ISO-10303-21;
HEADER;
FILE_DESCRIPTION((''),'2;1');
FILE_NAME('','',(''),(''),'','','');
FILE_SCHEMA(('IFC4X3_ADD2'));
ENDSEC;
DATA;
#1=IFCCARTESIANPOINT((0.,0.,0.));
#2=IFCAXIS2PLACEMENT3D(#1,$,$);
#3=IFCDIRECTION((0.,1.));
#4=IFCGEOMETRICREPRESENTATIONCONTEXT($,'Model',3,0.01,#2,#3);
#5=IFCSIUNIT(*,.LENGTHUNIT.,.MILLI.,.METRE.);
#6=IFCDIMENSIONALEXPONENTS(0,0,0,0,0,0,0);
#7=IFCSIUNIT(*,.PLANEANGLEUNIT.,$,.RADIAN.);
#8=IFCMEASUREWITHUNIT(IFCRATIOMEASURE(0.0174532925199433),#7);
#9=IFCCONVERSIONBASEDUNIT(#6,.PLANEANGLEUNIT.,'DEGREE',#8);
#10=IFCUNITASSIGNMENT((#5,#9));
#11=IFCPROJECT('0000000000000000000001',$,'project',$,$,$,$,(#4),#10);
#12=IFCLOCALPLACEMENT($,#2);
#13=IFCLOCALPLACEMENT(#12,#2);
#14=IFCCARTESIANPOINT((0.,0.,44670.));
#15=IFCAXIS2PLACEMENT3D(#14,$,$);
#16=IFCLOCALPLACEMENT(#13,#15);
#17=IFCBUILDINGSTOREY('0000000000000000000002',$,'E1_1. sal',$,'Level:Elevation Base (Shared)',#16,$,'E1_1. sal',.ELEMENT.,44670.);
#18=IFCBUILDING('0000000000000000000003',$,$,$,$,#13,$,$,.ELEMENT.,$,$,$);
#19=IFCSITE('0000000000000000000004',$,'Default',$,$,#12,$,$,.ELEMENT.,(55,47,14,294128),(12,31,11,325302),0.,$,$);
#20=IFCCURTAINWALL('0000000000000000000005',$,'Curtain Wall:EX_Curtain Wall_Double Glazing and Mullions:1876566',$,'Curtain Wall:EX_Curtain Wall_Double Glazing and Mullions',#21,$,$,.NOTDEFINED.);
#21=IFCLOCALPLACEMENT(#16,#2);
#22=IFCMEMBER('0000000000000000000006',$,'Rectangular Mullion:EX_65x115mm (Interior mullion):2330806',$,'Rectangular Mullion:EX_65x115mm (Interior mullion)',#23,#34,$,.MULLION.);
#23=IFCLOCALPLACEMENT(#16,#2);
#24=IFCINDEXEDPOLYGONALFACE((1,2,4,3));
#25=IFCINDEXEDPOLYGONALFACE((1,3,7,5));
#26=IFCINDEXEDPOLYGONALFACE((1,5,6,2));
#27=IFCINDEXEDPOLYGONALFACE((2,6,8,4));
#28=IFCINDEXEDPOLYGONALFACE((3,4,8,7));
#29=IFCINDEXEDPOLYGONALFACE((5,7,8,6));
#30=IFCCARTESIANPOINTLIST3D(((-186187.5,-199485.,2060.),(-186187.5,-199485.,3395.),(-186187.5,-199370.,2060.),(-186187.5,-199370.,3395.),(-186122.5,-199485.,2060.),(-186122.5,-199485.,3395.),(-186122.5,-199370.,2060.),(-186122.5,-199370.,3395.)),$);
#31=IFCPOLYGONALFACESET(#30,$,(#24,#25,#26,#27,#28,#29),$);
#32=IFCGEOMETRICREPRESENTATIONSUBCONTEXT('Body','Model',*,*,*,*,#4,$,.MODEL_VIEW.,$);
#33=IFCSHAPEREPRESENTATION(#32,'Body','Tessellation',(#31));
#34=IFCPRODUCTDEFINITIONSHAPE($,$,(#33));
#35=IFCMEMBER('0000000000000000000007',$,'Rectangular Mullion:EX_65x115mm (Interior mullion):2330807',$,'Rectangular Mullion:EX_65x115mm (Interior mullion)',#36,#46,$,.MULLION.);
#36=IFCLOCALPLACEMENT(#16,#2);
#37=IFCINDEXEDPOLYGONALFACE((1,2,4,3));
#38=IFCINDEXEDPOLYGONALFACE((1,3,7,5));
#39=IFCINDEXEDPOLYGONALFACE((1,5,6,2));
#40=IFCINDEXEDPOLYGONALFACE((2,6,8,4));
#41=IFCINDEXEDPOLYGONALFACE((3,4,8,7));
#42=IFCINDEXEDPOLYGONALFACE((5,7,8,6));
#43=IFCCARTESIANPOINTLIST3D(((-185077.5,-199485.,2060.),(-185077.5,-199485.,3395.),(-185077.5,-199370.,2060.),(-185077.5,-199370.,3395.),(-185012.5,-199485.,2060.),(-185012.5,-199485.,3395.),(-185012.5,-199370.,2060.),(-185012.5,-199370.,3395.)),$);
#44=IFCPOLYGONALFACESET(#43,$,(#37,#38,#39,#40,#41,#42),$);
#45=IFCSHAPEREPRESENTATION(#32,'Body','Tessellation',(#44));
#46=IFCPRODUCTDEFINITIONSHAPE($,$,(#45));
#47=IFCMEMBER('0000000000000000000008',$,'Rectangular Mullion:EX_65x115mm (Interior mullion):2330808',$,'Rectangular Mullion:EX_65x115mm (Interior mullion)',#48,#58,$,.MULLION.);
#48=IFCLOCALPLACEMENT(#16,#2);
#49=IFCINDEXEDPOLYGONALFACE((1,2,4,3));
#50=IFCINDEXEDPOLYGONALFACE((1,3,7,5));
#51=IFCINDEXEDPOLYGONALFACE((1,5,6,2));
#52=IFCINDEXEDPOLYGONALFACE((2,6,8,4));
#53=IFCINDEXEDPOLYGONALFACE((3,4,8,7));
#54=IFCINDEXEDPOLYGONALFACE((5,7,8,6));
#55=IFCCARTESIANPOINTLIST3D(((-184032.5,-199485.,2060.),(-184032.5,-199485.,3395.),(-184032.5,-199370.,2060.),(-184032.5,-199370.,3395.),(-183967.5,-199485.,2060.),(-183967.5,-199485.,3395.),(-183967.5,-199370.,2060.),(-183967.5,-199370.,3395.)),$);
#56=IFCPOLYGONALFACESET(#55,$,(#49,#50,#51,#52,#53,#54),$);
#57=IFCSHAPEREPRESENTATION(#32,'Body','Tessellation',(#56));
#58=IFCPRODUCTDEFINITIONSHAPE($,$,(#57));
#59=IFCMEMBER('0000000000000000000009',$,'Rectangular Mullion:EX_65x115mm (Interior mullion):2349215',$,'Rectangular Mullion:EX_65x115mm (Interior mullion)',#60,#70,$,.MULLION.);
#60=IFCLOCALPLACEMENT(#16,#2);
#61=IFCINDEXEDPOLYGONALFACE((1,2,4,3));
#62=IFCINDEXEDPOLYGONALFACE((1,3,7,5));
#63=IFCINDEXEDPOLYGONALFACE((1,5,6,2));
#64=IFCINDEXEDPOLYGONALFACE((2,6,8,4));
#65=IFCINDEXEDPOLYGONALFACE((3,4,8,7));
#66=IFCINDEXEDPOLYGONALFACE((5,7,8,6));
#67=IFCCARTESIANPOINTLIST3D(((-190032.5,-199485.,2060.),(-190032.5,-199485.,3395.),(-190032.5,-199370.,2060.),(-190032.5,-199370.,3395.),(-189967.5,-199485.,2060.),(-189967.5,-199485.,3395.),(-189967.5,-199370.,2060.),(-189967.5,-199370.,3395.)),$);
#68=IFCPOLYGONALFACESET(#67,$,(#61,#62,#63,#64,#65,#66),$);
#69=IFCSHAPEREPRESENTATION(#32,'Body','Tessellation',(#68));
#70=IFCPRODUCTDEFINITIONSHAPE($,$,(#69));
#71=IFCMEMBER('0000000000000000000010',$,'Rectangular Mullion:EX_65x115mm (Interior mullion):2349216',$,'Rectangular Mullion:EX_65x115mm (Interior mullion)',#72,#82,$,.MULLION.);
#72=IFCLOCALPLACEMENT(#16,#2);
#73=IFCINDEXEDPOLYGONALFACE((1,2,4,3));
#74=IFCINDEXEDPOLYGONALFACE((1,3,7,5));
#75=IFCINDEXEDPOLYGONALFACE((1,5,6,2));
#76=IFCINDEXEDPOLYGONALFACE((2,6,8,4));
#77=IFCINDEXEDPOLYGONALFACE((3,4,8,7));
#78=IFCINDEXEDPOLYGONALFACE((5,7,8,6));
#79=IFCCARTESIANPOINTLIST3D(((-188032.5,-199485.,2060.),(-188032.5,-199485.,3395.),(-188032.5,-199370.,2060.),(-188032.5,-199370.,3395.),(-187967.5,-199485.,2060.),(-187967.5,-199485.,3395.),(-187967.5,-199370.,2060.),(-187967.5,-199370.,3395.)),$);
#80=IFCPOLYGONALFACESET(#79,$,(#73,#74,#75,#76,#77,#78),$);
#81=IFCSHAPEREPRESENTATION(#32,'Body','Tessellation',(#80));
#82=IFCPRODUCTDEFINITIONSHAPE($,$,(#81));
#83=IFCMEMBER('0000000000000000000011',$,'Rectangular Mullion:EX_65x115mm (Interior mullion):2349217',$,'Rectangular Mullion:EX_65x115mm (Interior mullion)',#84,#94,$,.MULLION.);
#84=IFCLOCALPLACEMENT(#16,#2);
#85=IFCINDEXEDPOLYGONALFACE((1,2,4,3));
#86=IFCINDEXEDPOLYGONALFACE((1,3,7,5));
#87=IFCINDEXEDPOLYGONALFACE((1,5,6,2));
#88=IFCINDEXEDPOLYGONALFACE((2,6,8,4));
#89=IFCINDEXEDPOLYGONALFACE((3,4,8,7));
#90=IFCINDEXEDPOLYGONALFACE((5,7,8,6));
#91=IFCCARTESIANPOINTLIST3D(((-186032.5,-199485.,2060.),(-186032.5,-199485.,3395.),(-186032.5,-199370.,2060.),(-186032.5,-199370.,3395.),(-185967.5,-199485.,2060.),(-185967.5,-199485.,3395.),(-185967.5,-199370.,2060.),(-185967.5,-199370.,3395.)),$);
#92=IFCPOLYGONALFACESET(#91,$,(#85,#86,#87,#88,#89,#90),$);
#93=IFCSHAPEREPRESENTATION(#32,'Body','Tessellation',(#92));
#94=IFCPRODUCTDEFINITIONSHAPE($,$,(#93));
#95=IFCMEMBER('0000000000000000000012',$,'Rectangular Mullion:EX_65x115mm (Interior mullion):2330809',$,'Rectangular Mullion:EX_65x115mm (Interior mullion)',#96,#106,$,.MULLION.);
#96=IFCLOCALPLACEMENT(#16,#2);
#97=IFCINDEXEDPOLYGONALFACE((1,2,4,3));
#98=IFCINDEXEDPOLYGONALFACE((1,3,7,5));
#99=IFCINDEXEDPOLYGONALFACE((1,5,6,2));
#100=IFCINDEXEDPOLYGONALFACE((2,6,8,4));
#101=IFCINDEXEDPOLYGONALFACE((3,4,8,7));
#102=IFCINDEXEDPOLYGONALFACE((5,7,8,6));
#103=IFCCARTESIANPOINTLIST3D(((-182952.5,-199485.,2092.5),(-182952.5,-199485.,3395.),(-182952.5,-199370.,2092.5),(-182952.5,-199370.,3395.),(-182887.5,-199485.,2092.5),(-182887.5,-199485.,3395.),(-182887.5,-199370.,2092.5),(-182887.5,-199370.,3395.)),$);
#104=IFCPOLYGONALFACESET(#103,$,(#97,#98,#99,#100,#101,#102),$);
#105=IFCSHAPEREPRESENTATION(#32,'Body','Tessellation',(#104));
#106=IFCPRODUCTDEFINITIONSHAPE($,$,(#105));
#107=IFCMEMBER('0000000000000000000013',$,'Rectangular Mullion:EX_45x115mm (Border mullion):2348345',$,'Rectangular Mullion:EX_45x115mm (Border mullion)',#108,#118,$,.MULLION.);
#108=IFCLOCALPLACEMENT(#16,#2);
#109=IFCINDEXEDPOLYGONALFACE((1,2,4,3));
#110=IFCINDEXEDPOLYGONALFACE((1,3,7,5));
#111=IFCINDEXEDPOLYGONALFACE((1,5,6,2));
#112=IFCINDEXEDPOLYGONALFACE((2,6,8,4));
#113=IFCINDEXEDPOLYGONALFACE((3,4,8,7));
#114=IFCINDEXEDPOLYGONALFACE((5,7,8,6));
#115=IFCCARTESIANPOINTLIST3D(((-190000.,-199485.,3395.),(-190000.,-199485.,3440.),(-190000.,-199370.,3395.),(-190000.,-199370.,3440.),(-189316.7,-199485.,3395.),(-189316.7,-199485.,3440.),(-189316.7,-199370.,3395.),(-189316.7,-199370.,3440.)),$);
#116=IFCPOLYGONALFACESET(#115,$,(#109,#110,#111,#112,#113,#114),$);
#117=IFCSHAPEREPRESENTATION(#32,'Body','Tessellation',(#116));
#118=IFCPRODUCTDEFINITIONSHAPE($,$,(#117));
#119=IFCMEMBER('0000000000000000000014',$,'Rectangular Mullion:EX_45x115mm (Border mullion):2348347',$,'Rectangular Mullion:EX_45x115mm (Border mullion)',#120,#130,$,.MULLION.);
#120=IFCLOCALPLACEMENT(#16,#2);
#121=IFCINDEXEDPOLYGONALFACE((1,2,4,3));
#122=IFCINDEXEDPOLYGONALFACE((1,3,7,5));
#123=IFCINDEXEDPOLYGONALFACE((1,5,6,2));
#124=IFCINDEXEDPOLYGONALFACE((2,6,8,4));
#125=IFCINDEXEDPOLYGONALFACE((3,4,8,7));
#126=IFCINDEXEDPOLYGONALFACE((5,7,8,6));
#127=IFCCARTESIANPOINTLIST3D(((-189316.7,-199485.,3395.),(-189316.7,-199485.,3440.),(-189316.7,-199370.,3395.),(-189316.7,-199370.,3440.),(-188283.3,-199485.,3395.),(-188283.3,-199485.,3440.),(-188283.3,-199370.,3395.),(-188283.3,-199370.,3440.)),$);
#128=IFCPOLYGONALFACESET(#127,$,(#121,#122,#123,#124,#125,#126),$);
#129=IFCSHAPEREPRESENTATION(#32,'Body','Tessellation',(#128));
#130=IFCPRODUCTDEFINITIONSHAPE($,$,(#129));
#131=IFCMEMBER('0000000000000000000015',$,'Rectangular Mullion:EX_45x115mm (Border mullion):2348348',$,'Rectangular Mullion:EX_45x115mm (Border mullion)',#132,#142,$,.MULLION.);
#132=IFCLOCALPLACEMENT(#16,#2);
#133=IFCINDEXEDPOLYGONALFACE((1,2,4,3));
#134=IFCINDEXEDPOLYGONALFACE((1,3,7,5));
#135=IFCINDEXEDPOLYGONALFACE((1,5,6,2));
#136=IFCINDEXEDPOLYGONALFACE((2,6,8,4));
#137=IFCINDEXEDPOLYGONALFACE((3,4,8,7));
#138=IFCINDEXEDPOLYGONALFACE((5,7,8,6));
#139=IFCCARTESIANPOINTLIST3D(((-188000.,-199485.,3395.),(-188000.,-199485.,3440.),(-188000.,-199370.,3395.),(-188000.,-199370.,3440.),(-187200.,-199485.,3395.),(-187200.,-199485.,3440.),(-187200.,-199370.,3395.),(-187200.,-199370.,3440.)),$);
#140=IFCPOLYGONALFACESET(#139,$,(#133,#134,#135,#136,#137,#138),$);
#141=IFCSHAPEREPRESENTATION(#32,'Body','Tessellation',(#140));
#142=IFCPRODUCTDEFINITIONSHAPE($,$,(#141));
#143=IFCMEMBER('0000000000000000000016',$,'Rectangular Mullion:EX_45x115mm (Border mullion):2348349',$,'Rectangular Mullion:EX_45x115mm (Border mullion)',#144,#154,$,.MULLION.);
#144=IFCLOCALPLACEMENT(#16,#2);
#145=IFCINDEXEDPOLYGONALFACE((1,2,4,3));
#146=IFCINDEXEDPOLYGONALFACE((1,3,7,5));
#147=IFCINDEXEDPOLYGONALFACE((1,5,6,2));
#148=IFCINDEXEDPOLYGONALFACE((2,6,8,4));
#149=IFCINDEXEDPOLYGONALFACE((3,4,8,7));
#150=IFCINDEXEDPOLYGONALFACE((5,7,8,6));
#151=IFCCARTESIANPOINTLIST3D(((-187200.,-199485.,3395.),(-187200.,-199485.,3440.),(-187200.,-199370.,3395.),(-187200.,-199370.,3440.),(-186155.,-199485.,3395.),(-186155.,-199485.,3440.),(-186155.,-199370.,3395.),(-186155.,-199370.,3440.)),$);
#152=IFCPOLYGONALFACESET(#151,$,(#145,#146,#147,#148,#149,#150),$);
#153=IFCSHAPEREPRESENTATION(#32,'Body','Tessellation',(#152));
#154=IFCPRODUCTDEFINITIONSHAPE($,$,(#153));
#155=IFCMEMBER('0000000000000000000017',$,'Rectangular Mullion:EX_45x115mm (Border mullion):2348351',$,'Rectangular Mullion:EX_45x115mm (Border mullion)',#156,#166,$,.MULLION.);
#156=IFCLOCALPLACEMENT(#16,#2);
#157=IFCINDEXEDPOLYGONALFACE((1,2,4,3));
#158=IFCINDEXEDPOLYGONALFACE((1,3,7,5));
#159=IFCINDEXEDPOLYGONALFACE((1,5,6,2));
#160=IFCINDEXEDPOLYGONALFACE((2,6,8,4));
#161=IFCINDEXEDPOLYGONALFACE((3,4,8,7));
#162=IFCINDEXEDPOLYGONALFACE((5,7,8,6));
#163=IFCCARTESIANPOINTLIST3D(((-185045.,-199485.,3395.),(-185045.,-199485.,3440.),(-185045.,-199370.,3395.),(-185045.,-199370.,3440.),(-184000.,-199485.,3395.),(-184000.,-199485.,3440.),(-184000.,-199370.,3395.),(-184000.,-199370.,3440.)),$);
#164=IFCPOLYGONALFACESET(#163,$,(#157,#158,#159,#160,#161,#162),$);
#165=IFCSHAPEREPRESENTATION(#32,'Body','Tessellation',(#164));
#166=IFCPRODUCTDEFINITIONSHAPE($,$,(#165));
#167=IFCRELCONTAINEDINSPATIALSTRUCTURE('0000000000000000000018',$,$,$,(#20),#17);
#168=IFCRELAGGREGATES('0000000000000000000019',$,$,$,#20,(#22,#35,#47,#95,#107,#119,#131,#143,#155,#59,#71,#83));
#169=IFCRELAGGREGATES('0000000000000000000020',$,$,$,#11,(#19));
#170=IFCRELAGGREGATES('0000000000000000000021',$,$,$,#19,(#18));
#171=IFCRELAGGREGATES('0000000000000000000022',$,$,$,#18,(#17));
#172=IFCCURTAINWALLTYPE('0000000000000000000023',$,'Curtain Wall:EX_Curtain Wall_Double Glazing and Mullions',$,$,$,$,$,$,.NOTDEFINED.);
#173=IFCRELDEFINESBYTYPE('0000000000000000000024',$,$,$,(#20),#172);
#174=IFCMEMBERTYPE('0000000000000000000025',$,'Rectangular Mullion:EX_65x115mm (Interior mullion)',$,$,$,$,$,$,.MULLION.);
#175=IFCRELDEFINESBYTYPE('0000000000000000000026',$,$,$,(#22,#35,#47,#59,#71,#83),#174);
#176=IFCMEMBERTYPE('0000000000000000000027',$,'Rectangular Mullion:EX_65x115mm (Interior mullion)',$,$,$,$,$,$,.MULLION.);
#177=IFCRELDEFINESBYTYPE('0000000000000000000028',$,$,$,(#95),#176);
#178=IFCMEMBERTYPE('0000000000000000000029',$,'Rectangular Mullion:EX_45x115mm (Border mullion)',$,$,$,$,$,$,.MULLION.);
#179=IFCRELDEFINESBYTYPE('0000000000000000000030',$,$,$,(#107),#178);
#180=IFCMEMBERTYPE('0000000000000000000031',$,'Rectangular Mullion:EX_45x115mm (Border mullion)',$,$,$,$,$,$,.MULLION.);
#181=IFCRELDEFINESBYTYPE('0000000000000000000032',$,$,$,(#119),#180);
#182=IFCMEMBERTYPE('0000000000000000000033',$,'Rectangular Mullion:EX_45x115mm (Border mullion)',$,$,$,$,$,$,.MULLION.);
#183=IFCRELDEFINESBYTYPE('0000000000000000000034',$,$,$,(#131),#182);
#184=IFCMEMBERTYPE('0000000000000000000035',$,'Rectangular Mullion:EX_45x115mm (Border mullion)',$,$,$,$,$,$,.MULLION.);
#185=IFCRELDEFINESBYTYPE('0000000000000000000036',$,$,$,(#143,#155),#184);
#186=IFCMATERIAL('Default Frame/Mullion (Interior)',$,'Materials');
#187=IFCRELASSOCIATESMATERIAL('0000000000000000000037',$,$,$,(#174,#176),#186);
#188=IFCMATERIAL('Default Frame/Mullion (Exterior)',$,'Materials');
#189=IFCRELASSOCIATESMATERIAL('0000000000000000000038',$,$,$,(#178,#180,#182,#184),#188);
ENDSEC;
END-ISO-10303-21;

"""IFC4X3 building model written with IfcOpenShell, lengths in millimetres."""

from ifc_helpers import new_model, entity, si_unit, converted_unit, direction, frame, origin, origin_2d_with_axis, place, context, subcontext, project, spatial, rectangle, extrude, source, transform, mapped, material, material_profile, profile_set, type_object, type_shapes, element, aggregate, save


model = new_model("IFC4X3")

# Units and contexts
model_context = context("Model", 3, precision=0.01, world=origin(), true_north=direction((0.0, 1.0)))
body_context = subcontext(model_context, "Body", "Model", "MODEL_VIEW")
ifc_project = project(units=[si_unit("LENGTHUNIT", "METRE", prefix="MILLI"), converted_unit("PLANEANGLEUNIT", "DEGREE", entity("IfcRatioMeasure", 0.0174532925199433), si_unit("PLANEANGLEUNIT", "RADIAN"), dimensions=[0, 0, 0, 0, 0, 0, 0])], contexts=[model_context])

# Site, building, storey
site_placement = place(None, origin())
site = spatial("IfcSite", under=ifc_project, at=site_placement, Name="Default", CompositionType="ELEMENT", RefLatitude=(55, 47, 14, 294128), RefLongitude=(12, 31, 11, 325302), RefElevation=0.0)
building_placement = place(site_placement, origin())
building = spatial("IfcBuilding", under=site, at=building_placement, CompositionType="ELEMENT")
storey_placement = place(building_placement, frame((0.0, 0.0, 44670.0)))
storey = spatial("IfcBuildingStorey", under=building, at=storey_placement, Name="E1_1. sal", ObjectType="Level:Elevation Base (Shared)", LongName="E1_1. sal", CompositionType="ELEMENT", Elevation=44670.0)

# Curtain wall, members
curtain_wall_type = type_object("IfcCurtainWallType", Name="Curtain Wall:EX_Curtain Wall_Double Glazing and Mullions", PredefinedType="NOTDEFINED")
curtain_wall_placement = place(storey_placement, frame((0.0, 0.0, -44670.0)))
curtain_wall = element("IfcCurtainWall", 1, at=curtain_wall_placement, inside=storey, type_object=curtain_wall_type, Name="Curtain Wall:EX_Curtain Wall_Double Glazing and Mullions:1876566", ObjectType="Curtain Wall:EX_Curtain Wall_Double Glazing and Mullions", PredefinedType="NOTDEFINED")
ifc_material_1 = material(Name="Default Frame/Mullion (Interior)", Category="Materials")
ifc_material_profile_1 = material_profile(ifc_material_1, rectangle(XDim=115.0, YDim=65.0, at=origin_2d_with_axis()), Name="EX_65x115mm (Interior mullion)")
ifc_profile_set_1 = profile_set([ifc_material_profile_1], Name="EX_65x115mm (Interior mullion)")
member_type_1 = type_object("IfcMemberType", Name="Rectangular Mullion:EX_65x115mm (Interior mullion)", PredefinedType="MULLION", material=ifc_profile_set_1)
shared_shape_1 = source(origin(), body_context, "Body", "SweptSolid", [
    extrude(rectangle(XDim=115.0, YDim=65.0, at=origin_2d_with_axis()), frame((0.0, -57.5, -1335.0), z_axis=(0.0, 0.0, 1.0), x_axis=(0.0, -1.0, 0.0)), (0.0, 0.0, 1.0), 1335.0),
])
type_shapes(member_type_1, [shared_shape_1])
member_1_placement = place(curtain_wall_placement, frame((-186155.0, -199485.0, 46730.0), z_axis=(0.0, 0.0, -1.0), x_axis=(1.0, 0.0, 0.0)))
member_1 = element("IfcMember", 2, at=member_1_placement, type_object=member_type_1, Name="Rectangular Mullion:EX_65x115mm (Interior mullion):2330806", ObjectType="Rectangular Mullion:EX_65x115mm (Interior mullion)", PredefinedType="MULLION", context=body_context, shape_type="MappedRepresentation", body=[
    mapped(shared_shape_1, transform((0.0, 0.0, 0.0), scale=1.0)),
])
member_2_placement = place(curtain_wall_placement, frame((-185045.0, -199485.0, 46730.0), z_axis=(0.0, 0.0, -1.0), x_axis=(1.0, 0.0, 0.0)))
member_2 = element("IfcMember", 3, at=member_2_placement, type_object=member_type_1, Name="Rectangular Mullion:EX_65x115mm (Interior mullion):2330807", ObjectType="Rectangular Mullion:EX_65x115mm (Interior mullion)", PredefinedType="MULLION", context=body_context, shape_type="MappedRepresentation", body=[
    mapped(shared_shape_1, transform((0.0, 0.0, 0.0), scale=1.0)),
])
member_3_placement = place(curtain_wall_placement, frame((-184000.0, -199485.0, 46730.0), z_axis=(0.0, 0.0, -1.0), x_axis=(1.0, 0.0, 0.0)))
member_3 = element("IfcMember", 4, at=member_3_placement, type_object=member_type_1, Name="Rectangular Mullion:EX_65x115mm (Interior mullion):2330808", ObjectType="Rectangular Mullion:EX_65x115mm (Interior mullion)", PredefinedType="MULLION", context=body_context, shape_type="MappedRepresentation", body=[
    mapped(shared_shape_1, transform((0.0, 0.0, 0.0), scale=1.0)),
])
member_4_placement = place(curtain_wall_placement, frame((-190000.0, -199485.0, 46730.0), z_axis=(0.0, 0.0, -1.0), x_axis=(1.0, 0.0, 0.0)))
member_4 = element("IfcMember", 5, at=member_4_placement, type_object=member_type_1, Name="Rectangular Mullion:EX_65x115mm (Interior mullion):2349215", ObjectType="Rectangular Mullion:EX_65x115mm (Interior mullion)", PredefinedType="MULLION", context=body_context, shape_type="MappedRepresentation", body=[
    mapped(shared_shape_1, transform((0.0, 0.0, 0.0), scale=1.0)),
])
member_5_placement = place(curtain_wall_placement, frame((-188000.0, -199485.0, 46730.0), z_axis=(0.0, 0.0, -1.0), x_axis=(1.0, 0.0, 0.0)))
member_5 = element("IfcMember", 6, at=member_5_placement, type_object=member_type_1, Name="Rectangular Mullion:EX_65x115mm (Interior mullion):2349216", ObjectType="Rectangular Mullion:EX_65x115mm (Interior mullion)", PredefinedType="MULLION", context=body_context, shape_type="MappedRepresentation", body=[
    mapped(shared_shape_1, transform((0.0, 0.0, 0.0), scale=1.0)),
])
member_6_placement = place(curtain_wall_placement, frame((-186000.0, -199485.0, 46730.0), z_axis=(0.0, 0.0, -1.0), x_axis=(1.0, 0.0, 0.0)))
member_6 = element("IfcMember", 7, at=member_6_placement, type_object=member_type_1, Name="Rectangular Mullion:EX_65x115mm (Interior mullion):2349217", ObjectType="Rectangular Mullion:EX_65x115mm (Interior mullion)", PredefinedType="MULLION", context=body_context, shape_type="MappedRepresentation", body=[
    mapped(shared_shape_1, transform((0.0, 0.0, 0.0), scale=1.0)),
])
member_type_2 = type_object("IfcMemberType", Name="Rectangular Mullion:EX_65x115mm (Interior mullion)", PredefinedType="MULLION", material=ifc_profile_set_1)
shared_shape_2 = source(origin(), body_context, "Body", "SweptSolid", [
    extrude(rectangle(XDim=115.0, YDim=65.0, at=origin_2d_with_axis()), frame((0.0, -57.5, -1302.5), z_axis=(0.0, 0.0, 1.0), x_axis=(0.0, -1.0, 0.0)), (0.0, 0.0, 1.0), 1302.5),
])
type_shapes(member_type_2, [shared_shape_2])
member_7_placement = place(curtain_wall_placement, frame((-182920.0, -199485.0, 46762.5), z_axis=(0.0, 0.0, -1.0), x_axis=(1.0, 0.0, 0.0)))
member_7 = element("IfcMember", 8, at=member_7_placement, type_object=member_type_2, Name="Rectangular Mullion:EX_65x115mm (Interior mullion):2330809", ObjectType="Rectangular Mullion:EX_65x115mm (Interior mullion)", PredefinedType="MULLION", context=body_context, shape_type="MappedRepresentation", body=[
    mapped(shared_shape_2, transform((0.0, 0.0, 0.0), scale=1.0)),
])
ifc_material_2 = material(Name="Default Frame/Mullion (Exterior)", Category="Materials")
ifc_material_profile_2 = material_profile(ifc_material_2, rectangle(XDim=115.0, YDim=45.0, at=origin_2d_with_axis()), Name="EX_45x115mm (Border mullion)")
ifc_profile_set_2 = profile_set([ifc_material_profile_2], Name="EX_45x115mm (Border mullion)")
member_type_3 = type_object("IfcMemberType", Name="Rectangular Mullion:EX_45x115mm (Border mullion)", PredefinedType="MULLION", material=ifc_profile_set_2)
shared_shape_3 = source(origin(), body_context, "Body", "SweptSolid", [
    extrude(rectangle(XDim=115.0, YDim=45.0, at=origin_2d_with_axis()), frame((-22.5, -57.5, -683.3), z_axis=(0.0, 0.0, 1.0), x_axis=(0.0, -1.0, 0.0)), (0.0, 0.0, 1.0), 683.3),
])
type_shapes(member_type_3, [shared_shape_3])
member_8_placement = place(curtain_wall_placement, frame((-189316.7, -199485.0, 48110.0), z_axis=(1.0, 0.0, 0.0), x_axis=(0.0, 0.0, 1.0)))
member_8 = element("IfcMember", 9, at=member_8_placement, type_object=member_type_3, Name="Rectangular Mullion:EX_45x115mm (Border mullion):2348345", ObjectType="Rectangular Mullion:EX_45x115mm (Border mullion)", PredefinedType="MULLION", context=body_context, shape_type="MappedRepresentation", body=[
    mapped(shared_shape_3, transform((0.0, 0.0, 0.0), scale=1.0)),
])
member_type_4 = type_object("IfcMemberType", Name="Rectangular Mullion:EX_45x115mm (Border mullion)", PredefinedType="MULLION", material=ifc_profile_set_2)
shared_shape_4 = source(origin(), body_context, "Body", "SweptSolid", [
    extrude(rectangle(XDim=115.0, YDim=45.0, at=origin_2d_with_axis()), frame((-22.5, -57.5, -1033.3), z_axis=(0.0, 0.0, 1.0), x_axis=(0.0, -1.0, 0.0)), (0.0, 0.0, 1.0), 1033.3),
])
type_shapes(member_type_4, [shared_shape_4])
member_9_placement = place(curtain_wall_placement, frame((-188283.3, -199485.0, 48110.0), z_axis=(1.0, 0.0, 0.0), x_axis=(0.0, 0.0, 1.0)))
member_9 = element("IfcMember", 10, at=member_9_placement, type_object=member_type_4, Name="Rectangular Mullion:EX_45x115mm (Border mullion):2348347", ObjectType="Rectangular Mullion:EX_45x115mm (Border mullion)", PredefinedType="MULLION", context=body_context, shape_type="MappedRepresentation", body=[
    mapped(shared_shape_4, transform((0.0, 0.0, 0.0), scale=1.0)),
])
member_type_5 = type_object("IfcMemberType", Name="Rectangular Mullion:EX_45x115mm (Border mullion)", PredefinedType="MULLION", material=ifc_profile_set_2)
shared_shape_5 = source(origin(), body_context, "Body", "SweptSolid", [
    extrude(rectangle(XDim=115.0, YDim=45.0, at=origin_2d_with_axis()), frame((-22.5, -57.5, -800.0), z_axis=(0.0, 0.0, 1.0), x_axis=(0.0, -1.0, 0.0)), (0.0, 0.0, 1.0), 800.0),
])
type_shapes(member_type_5, [shared_shape_5])
member_10_placement = place(curtain_wall_placement, frame((-187200.0, -199485.0, 48110.0), z_axis=(1.0, 0.0, 0.0), x_axis=(0.0, 0.0, 1.0)))
member_10 = element("IfcMember", 11, at=member_10_placement, type_object=member_type_5, Name="Rectangular Mullion:EX_45x115mm (Border mullion):2348348", ObjectType="Rectangular Mullion:EX_45x115mm (Border mullion)", PredefinedType="MULLION", context=body_context, shape_type="MappedRepresentation", body=[
    mapped(shared_shape_5, transform((0.0, 0.0, 0.0), scale=1.0)),
])
member_type_6 = type_object("IfcMemberType", Name="Rectangular Mullion:EX_45x115mm (Border mullion)", PredefinedType="MULLION", material=ifc_profile_set_2)
shared_shape_6 = source(origin(), body_context, "Body", "SweptSolid", [
    extrude(rectangle(XDim=115.0, YDim=45.0, at=origin_2d_with_axis()), frame((-22.5, -57.5, -1045.0), z_axis=(0.0, 0.0, 1.0), x_axis=(0.0, -1.0, 0.0)), (0.0, 0.0, 1.0), 1045.0),
])
type_shapes(member_type_6, [shared_shape_6])
member_11_placement = place(curtain_wall_placement, frame((-186155.0, -199485.0, 48110.0), z_axis=(1.0, 0.0, 0.0), x_axis=(0.0, 0.0, 1.0)))
member_11 = element("IfcMember", 12, at=member_11_placement, type_object=member_type_6, Name="Rectangular Mullion:EX_45x115mm (Border mullion):2348349", ObjectType="Rectangular Mullion:EX_45x115mm (Border mullion)", PredefinedType="MULLION", context=body_context, shape_type="MappedRepresentation", body=[
    mapped(shared_shape_6, transform((0.0, 0.0, 0.0), scale=1.0)),
])
member_12_placement = place(curtain_wall_placement, frame((-184000.0, -199485.0, 48110.0), z_axis=(1.0, 0.0, 0.0), x_axis=(0.0, 0.0, 1.0)))
member_12 = element("IfcMember", 13, at=member_12_placement, type_object=member_type_6, Name="Rectangular Mullion:EX_45x115mm (Border mullion):2348351", ObjectType="Rectangular Mullion:EX_45x115mm (Border mullion)", PredefinedType="MULLION", context=body_context, shape_type="MappedRepresentation", body=[
    mapped(shared_shape_6, transform((0.0, 0.0, 0.0), scale=1.0)),
])
aggregate(curtain_wall, [member_1, member_2, member_3, member_7, member_8, member_9, member_10, member_11, member_12, member_4, member_5, member_6])

save(model, "model.ifc")
